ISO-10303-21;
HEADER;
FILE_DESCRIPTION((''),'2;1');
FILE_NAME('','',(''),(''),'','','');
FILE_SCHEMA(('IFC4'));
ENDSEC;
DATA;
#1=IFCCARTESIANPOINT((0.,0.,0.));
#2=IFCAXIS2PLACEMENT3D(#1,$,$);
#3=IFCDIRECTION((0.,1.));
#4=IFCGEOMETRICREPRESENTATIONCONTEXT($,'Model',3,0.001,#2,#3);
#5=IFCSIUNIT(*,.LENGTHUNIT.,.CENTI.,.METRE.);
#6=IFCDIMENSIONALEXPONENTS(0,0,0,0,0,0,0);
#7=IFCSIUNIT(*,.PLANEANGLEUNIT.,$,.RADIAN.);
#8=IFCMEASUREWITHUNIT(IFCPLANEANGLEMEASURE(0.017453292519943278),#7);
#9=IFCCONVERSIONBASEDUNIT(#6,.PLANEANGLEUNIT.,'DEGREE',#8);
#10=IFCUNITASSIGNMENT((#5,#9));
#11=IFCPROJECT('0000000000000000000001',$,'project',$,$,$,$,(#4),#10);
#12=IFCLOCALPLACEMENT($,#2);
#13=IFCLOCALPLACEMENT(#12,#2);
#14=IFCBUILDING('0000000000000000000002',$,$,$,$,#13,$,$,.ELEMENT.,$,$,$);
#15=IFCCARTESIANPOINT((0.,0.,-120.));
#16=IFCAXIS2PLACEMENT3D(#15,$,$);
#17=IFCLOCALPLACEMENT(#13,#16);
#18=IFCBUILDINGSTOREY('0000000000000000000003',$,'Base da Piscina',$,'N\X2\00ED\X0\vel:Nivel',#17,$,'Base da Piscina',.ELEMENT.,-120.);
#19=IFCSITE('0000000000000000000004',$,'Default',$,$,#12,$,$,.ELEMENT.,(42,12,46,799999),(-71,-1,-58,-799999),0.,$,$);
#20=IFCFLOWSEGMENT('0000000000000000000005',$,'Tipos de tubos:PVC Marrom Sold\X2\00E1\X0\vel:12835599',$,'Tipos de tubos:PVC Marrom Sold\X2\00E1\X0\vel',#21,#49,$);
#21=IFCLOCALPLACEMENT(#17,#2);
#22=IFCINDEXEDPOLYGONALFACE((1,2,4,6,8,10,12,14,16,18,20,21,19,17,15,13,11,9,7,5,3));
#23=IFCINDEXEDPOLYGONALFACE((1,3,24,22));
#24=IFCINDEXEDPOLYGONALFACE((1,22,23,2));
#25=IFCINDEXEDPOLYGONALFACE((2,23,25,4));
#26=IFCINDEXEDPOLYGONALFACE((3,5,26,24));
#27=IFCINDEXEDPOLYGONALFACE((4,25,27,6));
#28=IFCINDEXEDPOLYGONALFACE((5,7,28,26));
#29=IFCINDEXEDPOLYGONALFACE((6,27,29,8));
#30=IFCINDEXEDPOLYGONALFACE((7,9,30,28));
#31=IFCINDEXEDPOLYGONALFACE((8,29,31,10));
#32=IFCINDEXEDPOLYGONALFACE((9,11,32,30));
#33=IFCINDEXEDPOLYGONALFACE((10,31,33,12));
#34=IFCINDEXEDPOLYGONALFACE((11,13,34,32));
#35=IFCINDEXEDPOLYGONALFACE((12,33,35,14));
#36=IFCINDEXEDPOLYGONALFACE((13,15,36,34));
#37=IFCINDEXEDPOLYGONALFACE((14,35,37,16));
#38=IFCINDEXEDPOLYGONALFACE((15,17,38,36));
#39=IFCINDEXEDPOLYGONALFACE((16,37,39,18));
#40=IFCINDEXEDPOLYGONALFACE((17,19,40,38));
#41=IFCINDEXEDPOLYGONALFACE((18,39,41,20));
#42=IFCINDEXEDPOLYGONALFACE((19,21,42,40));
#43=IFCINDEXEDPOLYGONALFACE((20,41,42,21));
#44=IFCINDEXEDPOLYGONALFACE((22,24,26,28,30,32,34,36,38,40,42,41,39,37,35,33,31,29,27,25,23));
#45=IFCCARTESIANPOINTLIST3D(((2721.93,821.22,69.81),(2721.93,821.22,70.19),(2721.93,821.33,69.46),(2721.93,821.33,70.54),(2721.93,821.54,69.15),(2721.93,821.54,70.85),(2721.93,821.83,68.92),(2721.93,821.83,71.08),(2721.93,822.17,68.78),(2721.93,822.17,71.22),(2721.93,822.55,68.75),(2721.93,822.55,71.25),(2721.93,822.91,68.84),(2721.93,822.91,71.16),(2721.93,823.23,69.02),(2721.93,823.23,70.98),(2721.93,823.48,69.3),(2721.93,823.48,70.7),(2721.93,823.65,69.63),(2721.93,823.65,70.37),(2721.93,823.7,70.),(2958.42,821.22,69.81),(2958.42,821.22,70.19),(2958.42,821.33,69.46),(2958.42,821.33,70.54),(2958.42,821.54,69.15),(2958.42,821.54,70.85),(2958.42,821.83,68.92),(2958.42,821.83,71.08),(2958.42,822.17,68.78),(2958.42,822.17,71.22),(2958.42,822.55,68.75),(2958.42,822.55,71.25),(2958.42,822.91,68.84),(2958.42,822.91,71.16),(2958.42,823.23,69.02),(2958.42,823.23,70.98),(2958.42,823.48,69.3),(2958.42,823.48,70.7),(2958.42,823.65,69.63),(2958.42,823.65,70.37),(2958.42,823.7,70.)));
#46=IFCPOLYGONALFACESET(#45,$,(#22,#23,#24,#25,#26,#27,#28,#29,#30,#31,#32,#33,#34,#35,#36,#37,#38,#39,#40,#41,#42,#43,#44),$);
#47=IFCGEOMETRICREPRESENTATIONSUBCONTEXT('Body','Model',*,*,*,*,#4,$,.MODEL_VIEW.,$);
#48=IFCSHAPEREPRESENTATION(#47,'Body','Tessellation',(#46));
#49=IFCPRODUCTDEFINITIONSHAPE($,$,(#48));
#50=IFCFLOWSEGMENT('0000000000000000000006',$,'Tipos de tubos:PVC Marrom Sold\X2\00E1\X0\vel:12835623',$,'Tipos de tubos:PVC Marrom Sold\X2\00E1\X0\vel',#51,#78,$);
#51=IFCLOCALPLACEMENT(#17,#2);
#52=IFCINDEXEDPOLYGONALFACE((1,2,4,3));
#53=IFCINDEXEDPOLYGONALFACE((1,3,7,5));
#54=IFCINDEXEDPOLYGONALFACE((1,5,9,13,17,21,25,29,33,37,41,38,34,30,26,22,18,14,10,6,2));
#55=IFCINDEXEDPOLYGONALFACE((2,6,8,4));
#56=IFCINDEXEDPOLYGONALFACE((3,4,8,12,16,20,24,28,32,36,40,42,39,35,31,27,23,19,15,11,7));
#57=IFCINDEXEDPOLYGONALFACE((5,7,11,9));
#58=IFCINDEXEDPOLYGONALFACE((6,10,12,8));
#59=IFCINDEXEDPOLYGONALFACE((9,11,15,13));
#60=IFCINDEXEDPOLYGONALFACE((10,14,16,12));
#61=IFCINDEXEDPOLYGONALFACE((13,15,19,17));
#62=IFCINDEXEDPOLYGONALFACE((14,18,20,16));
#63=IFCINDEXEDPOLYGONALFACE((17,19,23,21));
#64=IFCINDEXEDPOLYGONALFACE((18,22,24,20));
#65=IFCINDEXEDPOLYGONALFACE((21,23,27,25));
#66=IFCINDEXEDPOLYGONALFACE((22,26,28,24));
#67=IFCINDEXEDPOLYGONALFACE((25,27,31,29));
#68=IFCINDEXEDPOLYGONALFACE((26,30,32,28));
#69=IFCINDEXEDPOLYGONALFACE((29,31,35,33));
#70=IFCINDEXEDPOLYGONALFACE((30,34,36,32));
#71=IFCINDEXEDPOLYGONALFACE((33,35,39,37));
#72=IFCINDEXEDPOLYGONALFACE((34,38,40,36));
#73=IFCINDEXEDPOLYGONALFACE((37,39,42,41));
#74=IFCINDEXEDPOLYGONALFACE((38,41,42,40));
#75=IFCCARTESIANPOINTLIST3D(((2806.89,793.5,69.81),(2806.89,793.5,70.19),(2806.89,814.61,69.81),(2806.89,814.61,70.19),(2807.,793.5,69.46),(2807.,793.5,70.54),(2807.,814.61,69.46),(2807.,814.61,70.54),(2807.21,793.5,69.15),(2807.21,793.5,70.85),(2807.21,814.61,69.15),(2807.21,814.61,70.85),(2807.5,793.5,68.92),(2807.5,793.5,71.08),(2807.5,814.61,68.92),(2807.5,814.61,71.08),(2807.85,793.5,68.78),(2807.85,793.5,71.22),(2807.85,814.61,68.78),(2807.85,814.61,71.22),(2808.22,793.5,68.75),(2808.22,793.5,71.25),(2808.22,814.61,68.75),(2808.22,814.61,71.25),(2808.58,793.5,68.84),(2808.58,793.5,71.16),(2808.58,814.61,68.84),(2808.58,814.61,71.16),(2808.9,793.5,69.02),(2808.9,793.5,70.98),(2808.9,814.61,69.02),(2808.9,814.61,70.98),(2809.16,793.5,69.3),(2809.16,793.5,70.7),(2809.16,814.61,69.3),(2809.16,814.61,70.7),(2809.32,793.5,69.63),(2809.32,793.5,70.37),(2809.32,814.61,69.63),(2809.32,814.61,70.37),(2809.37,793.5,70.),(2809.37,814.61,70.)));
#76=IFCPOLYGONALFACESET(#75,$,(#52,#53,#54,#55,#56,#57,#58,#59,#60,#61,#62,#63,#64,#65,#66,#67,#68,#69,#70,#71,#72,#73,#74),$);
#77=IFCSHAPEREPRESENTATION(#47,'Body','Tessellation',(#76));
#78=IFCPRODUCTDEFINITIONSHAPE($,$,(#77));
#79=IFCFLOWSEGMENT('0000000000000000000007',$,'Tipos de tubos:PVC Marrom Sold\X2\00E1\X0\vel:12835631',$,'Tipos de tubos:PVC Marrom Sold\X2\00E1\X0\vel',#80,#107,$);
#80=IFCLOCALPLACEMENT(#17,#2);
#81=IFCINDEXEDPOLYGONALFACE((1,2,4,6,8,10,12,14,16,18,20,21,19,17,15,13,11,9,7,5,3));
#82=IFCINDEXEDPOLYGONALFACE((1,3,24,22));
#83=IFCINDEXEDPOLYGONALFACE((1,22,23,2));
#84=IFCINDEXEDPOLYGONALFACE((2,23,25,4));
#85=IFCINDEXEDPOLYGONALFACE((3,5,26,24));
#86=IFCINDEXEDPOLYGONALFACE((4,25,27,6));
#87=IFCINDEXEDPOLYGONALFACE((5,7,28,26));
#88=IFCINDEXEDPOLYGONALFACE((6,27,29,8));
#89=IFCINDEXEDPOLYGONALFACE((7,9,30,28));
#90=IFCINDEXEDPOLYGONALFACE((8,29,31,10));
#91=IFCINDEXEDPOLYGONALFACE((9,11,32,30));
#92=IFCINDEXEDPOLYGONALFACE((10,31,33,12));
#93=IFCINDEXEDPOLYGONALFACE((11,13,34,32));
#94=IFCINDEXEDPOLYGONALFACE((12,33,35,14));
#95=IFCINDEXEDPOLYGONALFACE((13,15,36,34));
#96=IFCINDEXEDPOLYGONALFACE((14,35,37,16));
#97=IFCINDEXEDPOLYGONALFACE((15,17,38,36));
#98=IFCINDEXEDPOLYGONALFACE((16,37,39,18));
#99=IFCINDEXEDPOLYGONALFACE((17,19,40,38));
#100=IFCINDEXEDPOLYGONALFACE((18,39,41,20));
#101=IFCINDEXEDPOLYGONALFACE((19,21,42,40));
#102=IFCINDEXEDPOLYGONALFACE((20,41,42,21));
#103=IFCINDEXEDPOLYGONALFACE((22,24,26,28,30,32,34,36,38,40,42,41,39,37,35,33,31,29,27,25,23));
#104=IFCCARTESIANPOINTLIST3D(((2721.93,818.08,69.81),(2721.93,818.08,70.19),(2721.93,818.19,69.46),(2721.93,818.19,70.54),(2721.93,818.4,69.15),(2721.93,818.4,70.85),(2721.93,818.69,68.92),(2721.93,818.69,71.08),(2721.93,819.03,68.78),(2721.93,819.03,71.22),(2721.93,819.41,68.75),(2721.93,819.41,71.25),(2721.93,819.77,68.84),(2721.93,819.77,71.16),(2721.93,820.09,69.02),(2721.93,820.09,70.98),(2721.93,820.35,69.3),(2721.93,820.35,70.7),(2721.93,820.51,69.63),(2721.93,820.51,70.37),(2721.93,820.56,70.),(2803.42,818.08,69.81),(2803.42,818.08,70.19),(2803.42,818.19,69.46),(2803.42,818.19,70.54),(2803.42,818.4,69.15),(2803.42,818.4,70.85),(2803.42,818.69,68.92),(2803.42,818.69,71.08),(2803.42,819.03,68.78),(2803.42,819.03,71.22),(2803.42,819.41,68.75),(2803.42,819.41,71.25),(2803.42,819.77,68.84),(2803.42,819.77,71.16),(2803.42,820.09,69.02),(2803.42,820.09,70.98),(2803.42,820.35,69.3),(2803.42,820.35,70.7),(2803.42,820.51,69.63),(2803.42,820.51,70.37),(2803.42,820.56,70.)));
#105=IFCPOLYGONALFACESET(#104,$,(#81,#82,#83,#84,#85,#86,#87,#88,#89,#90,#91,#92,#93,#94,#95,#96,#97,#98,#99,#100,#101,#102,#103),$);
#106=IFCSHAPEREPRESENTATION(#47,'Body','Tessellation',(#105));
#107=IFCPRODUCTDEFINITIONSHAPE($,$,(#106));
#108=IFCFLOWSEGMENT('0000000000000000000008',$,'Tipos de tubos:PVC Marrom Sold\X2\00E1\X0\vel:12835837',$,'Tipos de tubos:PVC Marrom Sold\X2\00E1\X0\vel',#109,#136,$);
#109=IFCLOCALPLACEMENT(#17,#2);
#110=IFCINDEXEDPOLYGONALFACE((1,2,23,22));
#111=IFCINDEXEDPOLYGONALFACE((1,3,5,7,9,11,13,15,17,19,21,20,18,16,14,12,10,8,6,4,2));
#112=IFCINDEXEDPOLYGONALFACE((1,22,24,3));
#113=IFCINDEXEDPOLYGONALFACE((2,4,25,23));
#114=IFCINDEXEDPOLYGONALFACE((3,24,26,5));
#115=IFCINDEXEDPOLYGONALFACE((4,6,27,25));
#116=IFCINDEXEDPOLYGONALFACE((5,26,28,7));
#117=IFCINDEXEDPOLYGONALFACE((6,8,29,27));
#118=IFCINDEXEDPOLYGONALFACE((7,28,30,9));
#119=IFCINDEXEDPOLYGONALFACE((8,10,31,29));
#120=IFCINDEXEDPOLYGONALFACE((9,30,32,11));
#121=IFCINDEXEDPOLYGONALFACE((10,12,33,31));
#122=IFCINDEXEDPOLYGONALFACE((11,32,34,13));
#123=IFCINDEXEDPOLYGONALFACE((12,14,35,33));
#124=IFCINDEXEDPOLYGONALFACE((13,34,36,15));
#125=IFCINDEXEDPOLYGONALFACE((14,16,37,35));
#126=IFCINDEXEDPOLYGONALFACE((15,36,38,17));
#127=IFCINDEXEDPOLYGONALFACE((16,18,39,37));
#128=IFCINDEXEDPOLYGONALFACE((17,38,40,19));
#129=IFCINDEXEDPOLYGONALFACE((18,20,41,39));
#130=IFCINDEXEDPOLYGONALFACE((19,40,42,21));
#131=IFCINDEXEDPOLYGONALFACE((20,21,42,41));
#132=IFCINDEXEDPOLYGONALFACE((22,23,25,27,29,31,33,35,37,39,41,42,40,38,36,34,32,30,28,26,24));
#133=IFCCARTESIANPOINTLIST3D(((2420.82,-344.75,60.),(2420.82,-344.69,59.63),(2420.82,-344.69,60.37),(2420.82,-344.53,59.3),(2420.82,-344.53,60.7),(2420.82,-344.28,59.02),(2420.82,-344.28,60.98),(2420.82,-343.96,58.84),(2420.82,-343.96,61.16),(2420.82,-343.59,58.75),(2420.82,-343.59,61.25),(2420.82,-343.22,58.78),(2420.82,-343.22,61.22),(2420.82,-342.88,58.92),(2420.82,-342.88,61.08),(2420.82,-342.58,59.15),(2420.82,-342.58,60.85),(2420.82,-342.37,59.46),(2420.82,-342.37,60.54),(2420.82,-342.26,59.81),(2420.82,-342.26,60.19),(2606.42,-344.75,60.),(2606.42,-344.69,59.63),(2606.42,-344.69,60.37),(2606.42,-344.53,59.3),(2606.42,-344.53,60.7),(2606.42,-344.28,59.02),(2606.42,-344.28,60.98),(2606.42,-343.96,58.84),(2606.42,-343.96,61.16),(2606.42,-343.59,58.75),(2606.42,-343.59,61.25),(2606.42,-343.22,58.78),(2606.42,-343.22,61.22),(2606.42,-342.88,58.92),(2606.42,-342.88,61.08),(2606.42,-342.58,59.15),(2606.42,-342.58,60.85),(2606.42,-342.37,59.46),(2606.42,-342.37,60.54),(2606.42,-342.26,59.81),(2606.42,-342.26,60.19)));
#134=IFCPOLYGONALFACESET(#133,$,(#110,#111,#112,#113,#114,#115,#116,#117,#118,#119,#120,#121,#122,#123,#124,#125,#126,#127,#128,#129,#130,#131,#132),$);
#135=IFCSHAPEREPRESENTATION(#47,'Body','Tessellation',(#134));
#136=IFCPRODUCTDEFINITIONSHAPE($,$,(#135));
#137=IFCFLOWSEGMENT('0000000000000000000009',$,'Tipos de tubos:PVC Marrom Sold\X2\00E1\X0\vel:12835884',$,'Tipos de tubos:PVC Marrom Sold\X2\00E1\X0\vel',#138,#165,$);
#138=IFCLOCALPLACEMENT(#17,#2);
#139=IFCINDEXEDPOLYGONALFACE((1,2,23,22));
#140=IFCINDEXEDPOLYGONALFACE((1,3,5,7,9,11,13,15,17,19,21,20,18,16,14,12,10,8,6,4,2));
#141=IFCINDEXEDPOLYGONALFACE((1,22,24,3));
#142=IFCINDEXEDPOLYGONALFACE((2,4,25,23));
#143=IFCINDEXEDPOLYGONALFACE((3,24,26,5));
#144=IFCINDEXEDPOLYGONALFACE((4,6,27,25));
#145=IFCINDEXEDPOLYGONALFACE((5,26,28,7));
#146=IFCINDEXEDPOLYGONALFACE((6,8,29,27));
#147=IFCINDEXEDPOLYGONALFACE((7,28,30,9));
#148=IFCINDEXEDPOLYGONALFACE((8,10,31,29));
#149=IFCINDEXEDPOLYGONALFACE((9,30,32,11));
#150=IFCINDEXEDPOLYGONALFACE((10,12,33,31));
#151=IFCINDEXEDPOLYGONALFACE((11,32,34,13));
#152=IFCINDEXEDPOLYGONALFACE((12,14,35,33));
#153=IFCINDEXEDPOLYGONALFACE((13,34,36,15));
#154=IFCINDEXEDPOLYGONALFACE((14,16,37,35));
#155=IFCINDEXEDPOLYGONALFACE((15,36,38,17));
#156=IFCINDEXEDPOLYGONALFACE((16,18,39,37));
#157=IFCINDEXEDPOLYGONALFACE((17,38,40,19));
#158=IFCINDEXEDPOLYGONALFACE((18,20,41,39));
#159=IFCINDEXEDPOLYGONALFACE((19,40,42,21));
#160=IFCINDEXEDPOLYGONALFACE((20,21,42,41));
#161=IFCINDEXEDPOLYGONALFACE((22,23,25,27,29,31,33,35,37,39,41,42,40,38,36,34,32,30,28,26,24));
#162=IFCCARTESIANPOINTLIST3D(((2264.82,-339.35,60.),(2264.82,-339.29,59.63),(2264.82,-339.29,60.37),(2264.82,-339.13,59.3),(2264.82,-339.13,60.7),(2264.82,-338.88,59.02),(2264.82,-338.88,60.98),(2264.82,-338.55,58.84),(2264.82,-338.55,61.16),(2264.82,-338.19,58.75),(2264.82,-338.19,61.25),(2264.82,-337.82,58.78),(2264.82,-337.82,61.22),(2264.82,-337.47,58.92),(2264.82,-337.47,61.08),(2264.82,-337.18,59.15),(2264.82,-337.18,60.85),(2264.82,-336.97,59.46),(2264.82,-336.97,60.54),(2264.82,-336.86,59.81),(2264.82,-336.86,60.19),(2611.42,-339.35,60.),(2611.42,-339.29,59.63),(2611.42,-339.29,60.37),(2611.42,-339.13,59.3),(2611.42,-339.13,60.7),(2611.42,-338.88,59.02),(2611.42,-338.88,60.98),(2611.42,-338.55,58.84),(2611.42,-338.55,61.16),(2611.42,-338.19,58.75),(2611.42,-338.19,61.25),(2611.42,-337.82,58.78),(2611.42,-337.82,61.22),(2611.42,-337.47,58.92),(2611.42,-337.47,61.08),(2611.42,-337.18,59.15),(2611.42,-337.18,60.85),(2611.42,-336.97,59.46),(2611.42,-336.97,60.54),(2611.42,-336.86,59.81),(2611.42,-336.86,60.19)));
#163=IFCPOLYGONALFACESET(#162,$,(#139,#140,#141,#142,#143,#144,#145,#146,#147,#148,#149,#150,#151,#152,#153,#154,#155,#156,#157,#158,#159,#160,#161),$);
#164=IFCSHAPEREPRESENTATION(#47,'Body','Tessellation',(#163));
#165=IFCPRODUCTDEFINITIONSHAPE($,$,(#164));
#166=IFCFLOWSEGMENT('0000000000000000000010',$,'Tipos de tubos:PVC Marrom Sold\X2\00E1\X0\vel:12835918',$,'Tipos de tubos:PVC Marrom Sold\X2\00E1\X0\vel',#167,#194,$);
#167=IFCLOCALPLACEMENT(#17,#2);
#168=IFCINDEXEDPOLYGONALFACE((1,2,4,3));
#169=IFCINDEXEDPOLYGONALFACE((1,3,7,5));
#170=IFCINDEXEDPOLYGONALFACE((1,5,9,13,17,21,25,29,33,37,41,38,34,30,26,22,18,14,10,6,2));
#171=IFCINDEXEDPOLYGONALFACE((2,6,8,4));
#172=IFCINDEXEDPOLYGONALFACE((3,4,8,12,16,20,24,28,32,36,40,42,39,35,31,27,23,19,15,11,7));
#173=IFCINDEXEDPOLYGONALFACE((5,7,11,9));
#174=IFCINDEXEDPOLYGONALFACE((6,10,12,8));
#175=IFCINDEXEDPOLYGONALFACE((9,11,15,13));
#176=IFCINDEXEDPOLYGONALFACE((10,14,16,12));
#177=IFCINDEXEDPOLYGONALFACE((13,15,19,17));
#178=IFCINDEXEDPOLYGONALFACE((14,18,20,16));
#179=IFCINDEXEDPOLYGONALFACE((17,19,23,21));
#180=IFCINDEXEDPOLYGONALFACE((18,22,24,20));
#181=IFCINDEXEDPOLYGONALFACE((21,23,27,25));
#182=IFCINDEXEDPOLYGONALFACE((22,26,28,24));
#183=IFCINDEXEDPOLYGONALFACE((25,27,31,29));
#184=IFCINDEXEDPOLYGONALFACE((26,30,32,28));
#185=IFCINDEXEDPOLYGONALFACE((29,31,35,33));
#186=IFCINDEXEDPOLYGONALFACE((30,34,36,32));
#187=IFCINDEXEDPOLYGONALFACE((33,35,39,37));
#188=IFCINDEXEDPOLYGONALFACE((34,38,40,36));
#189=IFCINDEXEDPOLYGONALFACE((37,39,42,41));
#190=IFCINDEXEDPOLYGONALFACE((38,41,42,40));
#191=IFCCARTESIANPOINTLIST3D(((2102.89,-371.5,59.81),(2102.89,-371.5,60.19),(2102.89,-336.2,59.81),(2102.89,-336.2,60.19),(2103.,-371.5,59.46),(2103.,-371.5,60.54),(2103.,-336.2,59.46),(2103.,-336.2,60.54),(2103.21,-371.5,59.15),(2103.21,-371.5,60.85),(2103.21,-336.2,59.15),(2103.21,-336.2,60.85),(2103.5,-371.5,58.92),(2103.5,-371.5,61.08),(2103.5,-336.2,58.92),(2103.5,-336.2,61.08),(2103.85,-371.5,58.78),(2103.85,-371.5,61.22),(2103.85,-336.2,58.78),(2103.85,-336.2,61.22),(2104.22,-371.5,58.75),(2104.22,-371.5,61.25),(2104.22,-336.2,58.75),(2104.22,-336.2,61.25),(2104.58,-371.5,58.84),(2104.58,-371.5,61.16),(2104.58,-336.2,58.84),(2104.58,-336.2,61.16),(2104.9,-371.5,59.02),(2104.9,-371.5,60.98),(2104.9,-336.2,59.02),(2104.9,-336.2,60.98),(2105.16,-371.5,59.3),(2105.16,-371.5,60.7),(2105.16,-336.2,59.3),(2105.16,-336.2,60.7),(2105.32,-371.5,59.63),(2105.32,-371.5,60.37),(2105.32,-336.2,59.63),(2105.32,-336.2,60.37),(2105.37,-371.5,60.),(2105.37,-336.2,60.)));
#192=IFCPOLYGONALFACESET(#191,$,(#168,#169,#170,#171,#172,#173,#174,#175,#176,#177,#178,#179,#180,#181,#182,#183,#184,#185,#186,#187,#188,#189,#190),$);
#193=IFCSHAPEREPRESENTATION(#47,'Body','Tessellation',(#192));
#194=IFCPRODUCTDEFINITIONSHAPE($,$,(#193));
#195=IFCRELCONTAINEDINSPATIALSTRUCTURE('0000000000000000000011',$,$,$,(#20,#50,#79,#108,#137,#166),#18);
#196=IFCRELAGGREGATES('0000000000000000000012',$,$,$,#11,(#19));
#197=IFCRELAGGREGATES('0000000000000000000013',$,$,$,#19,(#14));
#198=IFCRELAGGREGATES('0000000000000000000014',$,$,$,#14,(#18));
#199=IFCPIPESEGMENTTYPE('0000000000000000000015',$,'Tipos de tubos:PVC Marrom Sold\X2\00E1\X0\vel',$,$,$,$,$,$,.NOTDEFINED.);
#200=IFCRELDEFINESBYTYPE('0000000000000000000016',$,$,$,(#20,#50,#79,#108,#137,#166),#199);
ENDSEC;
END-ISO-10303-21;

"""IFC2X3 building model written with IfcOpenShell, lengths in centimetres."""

from ifc_helpers import new_model, entity, si_unit, converted_unit, direction, frame, frame_2d, origin, origin_2d_with_axis, place, context, subcontext, project, spatial, circle, extrude, type_object, element, save


model = new_model("IFC2X3")

# Units and contexts
model_context = context("Model", 3, precision=0.001, world=origin(), true_north=direction((0.0, 1.0)))
body_context = subcontext(model_context, "Body", "Model", "MODEL_VIEW")
ifc_project = project(units=[si_unit("LENGTHUNIT", "METRE", prefix="CENTI"), converted_unit("PLANEANGLEUNIT", "DEGREE", entity("IfcPlaneAngleMeasure", 0.017453292519943278), si_unit("PLANEANGLEUNIT", "RADIAN"), dimensions=[0, 0, 0, 0, 0, 0, 0])], contexts=[model_context])

# Site, building, storey
site_placement = place(None, origin())
site = spatial("IfcSite", under=ifc_project, at=site_placement, Name="Default", CompositionType="ELEMENT", RefLatitude=(42, 12, 46, 799999), RefLongitude=(-71, -1, -58, -799999), RefElevation=0.0)
building_placement = place(site_placement, origin())
building = spatial("IfcBuilding", under=site, at=building_placement, CompositionType="ELEMENT")
storey_placement = place(building_placement, frame((0.0, 0.0, -120.0)))
storey = spatial("IfcBuildingStorey", under=building, at=storey_placement, Name="Base da Piscina", ObjectType="Nível:Nivel", LongName="Base da Piscina", CompositionType="ELEMENT", Elevation=-120.0)

# Flow segments
pipe_segment_type = type_object("IfcPipeSegmentType", Name="Tipos de tubos:PVC Marrom Soldável", PredefinedType="NOTDEFINED")
flow_segment_1_placement = place(storey_placement, origin())
element("IfcFlowSegment", 1, at=flow_segment_1_placement, inside=storey, type_object=pipe_segment_type, Name="Tipos de tubos:PVC Marrom Soldável:12835599", ObjectType="Tipos de tubos:PVC Marrom Soldável", context=body_context, shape_type="SweptSolid", body=[
    extrude(circle(Radius=1.25, at=frame_2d((0.0, 0.0), x_axis=(1.0, 0.0))), frame((2721.93, 822.45, 70.0), z_axis=(1.0, 0.0, 0.0), x_axis=(0.0, 1.0, 0.0)), (0.0, 0.0, 1.0), 236.49),
])
flow_segment_2_placement = place(storey_placement, origin())
element("IfcFlowSegment", 2, at=flow_segment_2_placement, inside=storey, type_object=pipe_segment_type, Name="Tipos de tubos:PVC Marrom Soldável:12835623", ObjectType="Tipos de tubos:PVC Marrom Soldável", context=body_context, shape_type="SweptSolid", body=[
    extrude(circle(Radius=1.25, at=origin_2d_with_axis()), frame((2808.12, 793.5, 70.0), z_axis=(0.0, 1.0, 0.0), x_axis=(1.0, 0.0, 0.0)), (0.0, 0.0, 1.0), 21.11),
])
flow_segment_3_placement = place(storey_placement, origin())
element("IfcFlowSegment", 3, at=flow_segment_3_placement, inside=storey, type_object=pipe_segment_type, Name="Tipos de tubos:PVC Marrom Soldável:12835631", ObjectType="Tipos de tubos:PVC Marrom Soldável", context=body_context, shape_type="SweptSolid", body=[
    extrude(circle(Radius=1.25, at=frame_2d((0.0, 0.0), x_axis=(1.0, 0.0))), frame((2721.93, 819.31, 70.0), z_axis=(1.0, 0.0, 0.0), x_axis=(0.0, 1.0, 0.0)), (0.0, 0.0, 1.0), 81.49),
])
flow_segment_4_placement = place(storey_placement, origin())
element("IfcFlowSegment", 4, at=flow_segment_4_placement, inside=storey, type_object=pipe_segment_type, Name="Tipos de tubos:PVC Marrom Soldável:12835837", ObjectType="Tipos de tubos:PVC Marrom Soldável", context=body_context, shape_type="SweptSolid", body=[
    extrude(circle(Radius=1.25, at=origin_2d_with_axis()), frame((2420.82, -343.5, 60.0), z_axis=(1.0, 0.0, 0.0), x_axis=(0.0, -1.0, 0.0)), (0.0, 0.0, 1.0), 185.6),
])
flow_segment_5_placement = place(storey_placement, origin())
element("IfcFlowSegment", 5, at=flow_segment_5_placement, inside=storey, type_object=pipe_segment_type, Name="Tipos de tubos:PVC Marrom Soldável:12835884", ObjectType="Tipos de tubos:PVC Marrom Soldável", context=body_context, shape_type="SweptSolid", body=[
    extrude(circle(Radius=1.25, at=origin_2d_with_axis()), frame((2264.82, -338.1, 60.0), z_axis=(1.0, 0.0, 0.0), x_axis=(0.0, -1.0, 0.0)), (0.0, 0.0, 1.0), 346.6),
])
flow_segment_6_placement = place(storey_placement, origin())
element("IfcFlowSegment", 6, at=flow_segment_6_placement, inside=storey, type_object=pipe_segment_type, Name="Tipos de tubos:PVC Marrom Soldável:12835918", ObjectType="Tipos de tubos:PVC Marrom Soldável", context=body_context, shape_type="SweptSolid", body=[
    extrude(circle(Radius=1.25, at=origin_2d_with_axis()), frame((2104.12, -371.5, 60.0), z_axis=(0.0, 1.0, 0.0), x_axis=(1.0, 0.0, 0.0)), (0.0, 0.0, 1.0), 35.3),
])

save(model, "model.ifc")
